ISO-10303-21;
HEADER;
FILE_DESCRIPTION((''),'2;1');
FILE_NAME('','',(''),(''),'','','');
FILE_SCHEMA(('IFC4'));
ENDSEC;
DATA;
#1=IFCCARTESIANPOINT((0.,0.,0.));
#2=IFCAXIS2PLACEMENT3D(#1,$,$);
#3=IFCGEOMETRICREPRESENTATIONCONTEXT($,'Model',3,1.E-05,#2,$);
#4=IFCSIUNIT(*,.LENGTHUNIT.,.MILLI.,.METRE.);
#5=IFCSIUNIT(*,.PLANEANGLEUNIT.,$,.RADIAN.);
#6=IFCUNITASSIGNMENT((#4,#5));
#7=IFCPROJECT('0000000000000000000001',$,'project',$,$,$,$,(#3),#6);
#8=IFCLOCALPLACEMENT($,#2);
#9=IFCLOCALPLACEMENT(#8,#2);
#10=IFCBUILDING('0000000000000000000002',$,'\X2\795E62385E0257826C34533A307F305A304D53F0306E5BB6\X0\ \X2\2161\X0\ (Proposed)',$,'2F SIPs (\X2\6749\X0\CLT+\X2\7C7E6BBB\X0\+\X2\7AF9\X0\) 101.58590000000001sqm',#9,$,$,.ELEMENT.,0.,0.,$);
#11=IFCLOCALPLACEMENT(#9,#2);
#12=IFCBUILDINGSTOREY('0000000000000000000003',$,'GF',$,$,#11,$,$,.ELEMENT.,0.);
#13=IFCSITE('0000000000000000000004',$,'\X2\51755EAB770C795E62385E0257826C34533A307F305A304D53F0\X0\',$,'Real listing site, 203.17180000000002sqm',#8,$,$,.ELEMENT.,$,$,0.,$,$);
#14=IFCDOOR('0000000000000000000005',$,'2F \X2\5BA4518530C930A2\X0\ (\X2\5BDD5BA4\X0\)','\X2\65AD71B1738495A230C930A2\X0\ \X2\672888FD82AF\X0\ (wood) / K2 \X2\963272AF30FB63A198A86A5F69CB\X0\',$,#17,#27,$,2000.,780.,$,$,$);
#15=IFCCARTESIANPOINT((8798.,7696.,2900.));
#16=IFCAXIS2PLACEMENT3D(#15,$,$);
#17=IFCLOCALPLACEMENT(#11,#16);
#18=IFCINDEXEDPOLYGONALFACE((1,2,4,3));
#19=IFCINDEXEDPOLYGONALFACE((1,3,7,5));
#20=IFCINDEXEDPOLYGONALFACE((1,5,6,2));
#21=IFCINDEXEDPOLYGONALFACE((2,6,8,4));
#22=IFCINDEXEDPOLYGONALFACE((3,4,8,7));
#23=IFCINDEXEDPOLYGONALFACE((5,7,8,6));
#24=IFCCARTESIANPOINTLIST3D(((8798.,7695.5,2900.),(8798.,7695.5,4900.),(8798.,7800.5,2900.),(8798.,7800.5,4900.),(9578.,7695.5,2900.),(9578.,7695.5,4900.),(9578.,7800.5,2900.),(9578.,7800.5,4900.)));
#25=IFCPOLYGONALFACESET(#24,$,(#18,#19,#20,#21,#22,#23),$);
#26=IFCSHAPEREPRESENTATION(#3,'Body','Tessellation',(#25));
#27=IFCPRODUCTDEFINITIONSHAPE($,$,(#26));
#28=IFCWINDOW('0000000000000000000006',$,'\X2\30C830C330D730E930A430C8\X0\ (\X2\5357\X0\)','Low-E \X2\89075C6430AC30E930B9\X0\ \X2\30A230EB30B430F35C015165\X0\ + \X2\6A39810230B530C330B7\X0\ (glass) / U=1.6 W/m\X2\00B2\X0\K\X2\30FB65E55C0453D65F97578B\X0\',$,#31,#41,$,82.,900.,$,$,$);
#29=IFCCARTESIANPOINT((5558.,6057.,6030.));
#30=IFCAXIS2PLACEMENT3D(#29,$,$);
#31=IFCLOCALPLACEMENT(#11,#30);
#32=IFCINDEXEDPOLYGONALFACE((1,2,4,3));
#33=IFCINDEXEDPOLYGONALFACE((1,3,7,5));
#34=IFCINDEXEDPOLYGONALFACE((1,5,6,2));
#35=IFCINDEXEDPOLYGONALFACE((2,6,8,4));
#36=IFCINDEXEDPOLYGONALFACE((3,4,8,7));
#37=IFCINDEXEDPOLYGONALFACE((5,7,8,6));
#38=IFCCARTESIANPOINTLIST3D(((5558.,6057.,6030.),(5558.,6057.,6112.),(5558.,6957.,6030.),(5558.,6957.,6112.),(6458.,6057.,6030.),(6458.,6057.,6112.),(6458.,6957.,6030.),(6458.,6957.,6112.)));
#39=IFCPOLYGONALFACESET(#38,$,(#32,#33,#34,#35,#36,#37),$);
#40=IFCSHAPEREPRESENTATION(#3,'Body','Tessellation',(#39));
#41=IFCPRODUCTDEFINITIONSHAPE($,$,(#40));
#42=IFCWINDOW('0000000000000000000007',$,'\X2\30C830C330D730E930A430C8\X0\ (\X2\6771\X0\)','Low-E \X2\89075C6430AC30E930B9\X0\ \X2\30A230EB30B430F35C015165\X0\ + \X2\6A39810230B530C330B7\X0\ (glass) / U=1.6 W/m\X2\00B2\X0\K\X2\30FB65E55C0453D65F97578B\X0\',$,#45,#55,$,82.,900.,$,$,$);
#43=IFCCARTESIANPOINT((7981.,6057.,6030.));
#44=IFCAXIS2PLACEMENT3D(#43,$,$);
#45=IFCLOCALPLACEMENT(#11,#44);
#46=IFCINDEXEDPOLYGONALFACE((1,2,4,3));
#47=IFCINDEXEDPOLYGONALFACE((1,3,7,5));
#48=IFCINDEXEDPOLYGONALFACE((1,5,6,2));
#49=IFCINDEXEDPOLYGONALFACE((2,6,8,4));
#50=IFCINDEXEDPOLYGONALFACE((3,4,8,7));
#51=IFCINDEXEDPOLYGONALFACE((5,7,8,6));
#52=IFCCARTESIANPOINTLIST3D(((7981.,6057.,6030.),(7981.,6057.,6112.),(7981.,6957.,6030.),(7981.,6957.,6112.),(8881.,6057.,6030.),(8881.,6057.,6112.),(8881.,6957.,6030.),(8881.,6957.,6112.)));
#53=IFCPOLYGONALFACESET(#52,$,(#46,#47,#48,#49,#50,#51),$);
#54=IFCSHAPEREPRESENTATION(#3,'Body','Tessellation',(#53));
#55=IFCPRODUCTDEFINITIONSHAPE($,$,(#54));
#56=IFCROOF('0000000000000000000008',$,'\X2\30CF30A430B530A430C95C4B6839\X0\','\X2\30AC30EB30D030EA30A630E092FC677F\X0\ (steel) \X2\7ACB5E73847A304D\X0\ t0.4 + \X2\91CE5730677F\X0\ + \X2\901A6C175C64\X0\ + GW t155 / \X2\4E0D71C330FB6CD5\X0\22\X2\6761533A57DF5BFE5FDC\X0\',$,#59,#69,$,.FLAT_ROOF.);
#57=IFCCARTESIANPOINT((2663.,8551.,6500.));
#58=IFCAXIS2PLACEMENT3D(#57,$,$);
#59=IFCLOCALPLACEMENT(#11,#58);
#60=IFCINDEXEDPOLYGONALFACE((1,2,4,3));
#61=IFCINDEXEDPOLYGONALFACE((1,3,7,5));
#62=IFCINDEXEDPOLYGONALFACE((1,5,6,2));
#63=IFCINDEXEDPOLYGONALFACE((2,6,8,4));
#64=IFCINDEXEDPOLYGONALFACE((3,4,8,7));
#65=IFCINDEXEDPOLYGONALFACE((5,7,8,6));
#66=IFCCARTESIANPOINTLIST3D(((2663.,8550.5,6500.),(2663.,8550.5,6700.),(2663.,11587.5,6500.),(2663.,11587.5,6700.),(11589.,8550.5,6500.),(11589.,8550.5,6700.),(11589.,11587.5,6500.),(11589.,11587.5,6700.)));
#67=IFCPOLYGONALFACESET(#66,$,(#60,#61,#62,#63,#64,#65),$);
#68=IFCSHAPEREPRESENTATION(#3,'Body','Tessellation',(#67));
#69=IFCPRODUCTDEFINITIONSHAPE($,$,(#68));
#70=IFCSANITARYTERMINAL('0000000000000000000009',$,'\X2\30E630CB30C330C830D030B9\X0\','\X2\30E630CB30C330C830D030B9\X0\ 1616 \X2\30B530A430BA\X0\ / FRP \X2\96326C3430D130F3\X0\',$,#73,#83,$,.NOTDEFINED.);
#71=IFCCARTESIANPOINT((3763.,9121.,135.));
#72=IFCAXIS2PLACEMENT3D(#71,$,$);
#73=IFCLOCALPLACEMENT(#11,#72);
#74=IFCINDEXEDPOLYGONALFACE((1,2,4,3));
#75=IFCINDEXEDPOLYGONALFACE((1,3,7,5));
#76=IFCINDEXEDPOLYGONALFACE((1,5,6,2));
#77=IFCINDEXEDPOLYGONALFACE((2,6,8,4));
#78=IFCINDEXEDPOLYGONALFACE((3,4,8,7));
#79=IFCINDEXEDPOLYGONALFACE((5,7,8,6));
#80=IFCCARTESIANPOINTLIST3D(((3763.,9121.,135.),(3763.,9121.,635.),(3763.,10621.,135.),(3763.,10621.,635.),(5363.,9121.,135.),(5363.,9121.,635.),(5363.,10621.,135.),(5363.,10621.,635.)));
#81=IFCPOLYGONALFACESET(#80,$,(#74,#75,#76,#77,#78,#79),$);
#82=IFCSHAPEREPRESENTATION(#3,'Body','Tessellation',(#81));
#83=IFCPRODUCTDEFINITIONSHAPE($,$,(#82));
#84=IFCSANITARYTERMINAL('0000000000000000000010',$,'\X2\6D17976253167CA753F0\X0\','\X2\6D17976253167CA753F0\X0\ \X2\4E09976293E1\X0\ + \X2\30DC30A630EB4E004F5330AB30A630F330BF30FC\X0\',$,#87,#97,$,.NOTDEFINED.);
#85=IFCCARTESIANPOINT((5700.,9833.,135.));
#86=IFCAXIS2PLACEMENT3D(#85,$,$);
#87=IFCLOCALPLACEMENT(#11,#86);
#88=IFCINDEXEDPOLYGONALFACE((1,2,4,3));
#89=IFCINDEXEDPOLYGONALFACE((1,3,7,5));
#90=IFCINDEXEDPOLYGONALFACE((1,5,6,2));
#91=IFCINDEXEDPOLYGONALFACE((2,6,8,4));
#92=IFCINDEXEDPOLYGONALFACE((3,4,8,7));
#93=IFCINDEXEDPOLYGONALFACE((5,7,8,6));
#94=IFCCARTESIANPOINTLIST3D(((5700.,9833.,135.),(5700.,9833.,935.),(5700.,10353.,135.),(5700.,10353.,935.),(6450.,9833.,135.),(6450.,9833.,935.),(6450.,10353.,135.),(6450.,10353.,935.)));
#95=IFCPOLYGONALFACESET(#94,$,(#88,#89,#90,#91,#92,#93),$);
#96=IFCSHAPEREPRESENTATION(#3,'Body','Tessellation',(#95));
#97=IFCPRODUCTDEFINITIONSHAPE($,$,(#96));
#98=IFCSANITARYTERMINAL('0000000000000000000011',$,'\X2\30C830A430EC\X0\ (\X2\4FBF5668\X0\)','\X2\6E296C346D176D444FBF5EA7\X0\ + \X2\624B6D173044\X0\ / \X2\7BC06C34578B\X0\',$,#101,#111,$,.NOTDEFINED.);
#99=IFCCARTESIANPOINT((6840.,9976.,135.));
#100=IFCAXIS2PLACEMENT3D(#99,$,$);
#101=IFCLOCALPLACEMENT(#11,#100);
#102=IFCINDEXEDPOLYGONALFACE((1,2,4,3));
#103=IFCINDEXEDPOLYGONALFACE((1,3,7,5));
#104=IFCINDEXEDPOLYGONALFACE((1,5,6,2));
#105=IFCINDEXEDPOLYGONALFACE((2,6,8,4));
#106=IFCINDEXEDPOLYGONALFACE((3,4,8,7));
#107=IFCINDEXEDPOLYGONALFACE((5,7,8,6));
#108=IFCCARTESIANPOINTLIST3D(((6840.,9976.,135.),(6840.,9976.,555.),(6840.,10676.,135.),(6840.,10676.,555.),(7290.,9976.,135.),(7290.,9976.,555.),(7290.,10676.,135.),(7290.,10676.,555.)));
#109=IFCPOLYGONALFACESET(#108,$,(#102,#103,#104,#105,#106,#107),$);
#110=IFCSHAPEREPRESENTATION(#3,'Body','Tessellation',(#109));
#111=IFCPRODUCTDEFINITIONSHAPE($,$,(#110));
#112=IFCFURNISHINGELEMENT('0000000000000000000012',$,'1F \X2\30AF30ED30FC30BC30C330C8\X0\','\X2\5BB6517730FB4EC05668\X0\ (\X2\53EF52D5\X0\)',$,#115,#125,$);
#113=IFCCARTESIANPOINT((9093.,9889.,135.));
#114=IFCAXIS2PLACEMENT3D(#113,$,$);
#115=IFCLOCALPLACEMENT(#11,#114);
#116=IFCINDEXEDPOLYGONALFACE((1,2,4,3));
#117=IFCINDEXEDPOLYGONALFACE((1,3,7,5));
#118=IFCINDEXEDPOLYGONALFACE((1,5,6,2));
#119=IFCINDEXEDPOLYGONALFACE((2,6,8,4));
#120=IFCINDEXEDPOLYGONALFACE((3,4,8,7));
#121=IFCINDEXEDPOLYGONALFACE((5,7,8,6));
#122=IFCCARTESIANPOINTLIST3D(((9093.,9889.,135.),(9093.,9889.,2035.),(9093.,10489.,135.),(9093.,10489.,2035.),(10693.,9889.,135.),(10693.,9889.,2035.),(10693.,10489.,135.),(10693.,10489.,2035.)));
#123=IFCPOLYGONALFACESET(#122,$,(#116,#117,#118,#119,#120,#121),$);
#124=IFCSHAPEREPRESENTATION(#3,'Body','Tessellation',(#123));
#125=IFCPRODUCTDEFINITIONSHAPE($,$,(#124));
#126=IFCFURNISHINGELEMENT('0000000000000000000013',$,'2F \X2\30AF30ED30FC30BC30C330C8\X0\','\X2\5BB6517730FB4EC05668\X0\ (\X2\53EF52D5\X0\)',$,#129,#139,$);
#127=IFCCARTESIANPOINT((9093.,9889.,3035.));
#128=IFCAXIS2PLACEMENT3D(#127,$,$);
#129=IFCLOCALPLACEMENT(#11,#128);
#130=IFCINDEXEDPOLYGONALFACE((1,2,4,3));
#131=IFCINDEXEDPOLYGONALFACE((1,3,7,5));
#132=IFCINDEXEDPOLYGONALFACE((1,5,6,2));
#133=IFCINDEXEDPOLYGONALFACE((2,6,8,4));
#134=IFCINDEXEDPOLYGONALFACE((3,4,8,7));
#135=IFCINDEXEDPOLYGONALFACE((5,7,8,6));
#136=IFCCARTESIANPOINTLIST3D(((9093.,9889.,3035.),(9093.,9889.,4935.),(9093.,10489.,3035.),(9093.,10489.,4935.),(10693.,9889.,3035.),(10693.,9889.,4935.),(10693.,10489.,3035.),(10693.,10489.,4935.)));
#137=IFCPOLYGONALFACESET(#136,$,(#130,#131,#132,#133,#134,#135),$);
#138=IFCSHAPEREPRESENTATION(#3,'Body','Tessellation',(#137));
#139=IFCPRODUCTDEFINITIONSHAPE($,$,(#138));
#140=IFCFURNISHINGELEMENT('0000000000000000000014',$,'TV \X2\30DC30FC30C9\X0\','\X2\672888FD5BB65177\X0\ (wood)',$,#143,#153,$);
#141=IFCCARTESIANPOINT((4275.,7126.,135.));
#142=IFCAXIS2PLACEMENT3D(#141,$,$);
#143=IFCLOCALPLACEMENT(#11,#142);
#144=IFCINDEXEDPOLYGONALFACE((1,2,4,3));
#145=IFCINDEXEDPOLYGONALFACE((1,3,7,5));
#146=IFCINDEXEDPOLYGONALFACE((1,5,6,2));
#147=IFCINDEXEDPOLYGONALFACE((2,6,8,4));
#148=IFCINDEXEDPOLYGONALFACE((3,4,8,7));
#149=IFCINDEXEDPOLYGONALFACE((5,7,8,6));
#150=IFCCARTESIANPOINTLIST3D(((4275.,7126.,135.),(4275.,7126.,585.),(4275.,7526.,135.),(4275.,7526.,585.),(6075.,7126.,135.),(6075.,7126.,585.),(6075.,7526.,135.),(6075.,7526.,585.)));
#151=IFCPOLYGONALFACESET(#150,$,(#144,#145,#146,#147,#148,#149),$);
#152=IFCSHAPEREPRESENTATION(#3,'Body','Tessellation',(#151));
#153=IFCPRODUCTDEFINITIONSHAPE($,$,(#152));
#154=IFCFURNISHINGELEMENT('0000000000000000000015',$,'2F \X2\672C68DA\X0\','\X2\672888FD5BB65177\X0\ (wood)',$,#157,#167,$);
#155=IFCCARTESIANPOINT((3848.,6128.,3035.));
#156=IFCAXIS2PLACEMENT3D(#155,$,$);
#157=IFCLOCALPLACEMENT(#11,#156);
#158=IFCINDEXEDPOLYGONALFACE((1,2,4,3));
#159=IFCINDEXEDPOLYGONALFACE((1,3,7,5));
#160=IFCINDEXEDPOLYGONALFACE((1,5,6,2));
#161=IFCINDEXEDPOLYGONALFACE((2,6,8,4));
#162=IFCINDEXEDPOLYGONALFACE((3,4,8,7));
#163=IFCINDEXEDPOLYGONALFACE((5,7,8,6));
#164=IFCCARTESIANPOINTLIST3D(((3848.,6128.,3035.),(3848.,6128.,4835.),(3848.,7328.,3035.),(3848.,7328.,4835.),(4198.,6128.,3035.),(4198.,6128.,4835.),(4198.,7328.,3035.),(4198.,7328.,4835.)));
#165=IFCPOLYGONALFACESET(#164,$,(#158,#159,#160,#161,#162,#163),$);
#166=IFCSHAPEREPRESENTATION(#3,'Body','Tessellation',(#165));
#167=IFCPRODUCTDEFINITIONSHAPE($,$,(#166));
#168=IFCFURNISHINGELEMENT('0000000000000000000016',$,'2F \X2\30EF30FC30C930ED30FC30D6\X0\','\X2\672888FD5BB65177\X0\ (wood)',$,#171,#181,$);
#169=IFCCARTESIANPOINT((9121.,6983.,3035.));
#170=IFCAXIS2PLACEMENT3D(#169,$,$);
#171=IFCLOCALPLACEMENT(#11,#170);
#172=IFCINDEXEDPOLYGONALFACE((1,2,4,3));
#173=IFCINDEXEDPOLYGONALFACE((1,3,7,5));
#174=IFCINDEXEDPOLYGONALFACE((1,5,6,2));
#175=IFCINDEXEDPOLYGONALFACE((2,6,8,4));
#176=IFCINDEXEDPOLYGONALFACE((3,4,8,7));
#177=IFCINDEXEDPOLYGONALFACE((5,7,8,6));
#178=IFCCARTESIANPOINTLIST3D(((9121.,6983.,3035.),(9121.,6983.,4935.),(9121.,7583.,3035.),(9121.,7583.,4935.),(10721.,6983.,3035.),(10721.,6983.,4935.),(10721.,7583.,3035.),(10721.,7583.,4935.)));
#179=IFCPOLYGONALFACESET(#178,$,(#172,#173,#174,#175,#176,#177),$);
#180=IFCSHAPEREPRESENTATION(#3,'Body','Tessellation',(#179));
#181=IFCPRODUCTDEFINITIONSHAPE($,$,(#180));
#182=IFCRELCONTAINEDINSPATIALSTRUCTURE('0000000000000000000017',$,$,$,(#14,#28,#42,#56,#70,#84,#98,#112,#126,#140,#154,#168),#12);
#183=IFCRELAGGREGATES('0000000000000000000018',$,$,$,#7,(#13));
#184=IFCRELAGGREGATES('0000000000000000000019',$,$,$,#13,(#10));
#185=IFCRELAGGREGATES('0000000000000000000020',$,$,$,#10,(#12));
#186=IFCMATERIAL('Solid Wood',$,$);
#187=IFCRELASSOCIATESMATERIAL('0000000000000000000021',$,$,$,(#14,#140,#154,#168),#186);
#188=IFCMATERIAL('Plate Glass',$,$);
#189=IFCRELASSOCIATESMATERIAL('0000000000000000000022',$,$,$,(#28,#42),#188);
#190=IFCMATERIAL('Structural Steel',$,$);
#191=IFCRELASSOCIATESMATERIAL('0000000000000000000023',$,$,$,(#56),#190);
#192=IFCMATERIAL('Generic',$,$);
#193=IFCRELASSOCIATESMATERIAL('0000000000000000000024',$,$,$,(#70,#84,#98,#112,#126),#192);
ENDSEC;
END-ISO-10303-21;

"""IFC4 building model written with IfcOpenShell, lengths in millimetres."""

from ifc_helpers import new_model, si_unit, frame, frame_2d, origin, place, context, project, spatial, rectangle, extrude, material, element, save


model = new_model("IFC4")

# Units and contexts
model_context = context("Model", 3, precision=1e-05, world=origin())
ifc_project = project(units=[si_unit("LENGTHUNIT", "METRE", prefix="MILLI"), si_unit("PLANEANGLEUNIT", "RADIAN")], contexts=[model_context])

# Site, building, storey
site_placement = place(None, origin())
site = spatial("IfcSite", under=ifc_project, at=site_placement, Name="兵庫県神戸市垂水区みずき台", ObjectType="Real listing site, 203.17180000000002sqm", CompositionType="ELEMENT", RefElevation=0.0)
building_placement = place(site_placement, origin())
building = spatial("IfcBuilding", under=site, at=building_placement, Name="神戸市垂水区みずき台の家 Ⅱ (Proposed)", ObjectType="2F SIPs (杉CLT+籾殻+竹) 101.58590000000001sqm", CompositionType="ELEMENT", ElevationOfRefHeight=0.0, ElevationOfTerrain=0.0)
storey_placement = place(building_placement, origin())
storey = spatial("IfcBuildingStorey", under=building, at=storey_placement, Name="GF", CompositionType="ELEMENT", Elevation=0.0)

# Shared definitions
ifc_material_1 = material(Name="Solid Wood")
ifc_material_2 = material(Name="Plate Glass")

# Door
door_1_placement = place(storey_placement, frame((8798.0, 7696.0, 2900.0)))
element("IfcDoor", 1, at=door_1_placement, inside=storey, material=ifc_material_1, Name="2F 室内ドア (寝室)", Description="断熱玄関ドア 木製芯 (wood) / K2 防犯・採風機構", OverallHeight=2000.0, OverallWidth=780.0, context=model_context, shape_type="SweptSolid", body=[
    extrude(rectangle(XDim=780.0, YDim=105.0, at=frame_2d((390.0, 52.0))), frame((8798.0, 7696.0, 2900.0)), (0.0, 0.0, 1.0), 2000.0),
])

# Windows
window_1_placement = place(storey_placement, frame((5558.0, 6057.0, 6030.0)))
element("IfcWindow", 2, at=window_1_placement, inside=storey, material=ifc_material_2, Name="トップライト (南)", Description="Low-E 複層ガラス アルゴン封入 + 樹脂サッシ (glass) / U=1.6 W/m²K・日射取得型", OverallHeight=82.0, OverallWidth=900.0, context=model_context, shape_type="SweptSolid", body=[
    extrude(rectangle(XDim=900.0, YDim=900.0, at=frame_2d((450.0, 450.0))), frame((5558.0, 6057.0, 6030.0)), (0.0, 0.0, 1.0), 82.0),
])
window_2_placement = place(storey_placement, frame((7981.0, 6057.0, 6030.0)))
element("IfcWindow", 3, at=window_2_placement, inside=storey, material=ifc_material_2, Name="トップライト (東)", Description="Low-E 複層ガラス アルゴン封入 + 樹脂サッシ (glass) / U=1.6 W/m²K・日射取得型", OverallHeight=82.0, OverallWidth=900.0, context=model_context, shape_type="SweptSolid", body=[
    extrude(rectangle(XDim=900.0, YDim=900.0, at=frame_2d((450.0, 450.0))), frame((7981.0, 6057.0, 6030.0)), (0.0, 0.0, 1.0), 82.0),
])

# Roof
ifc_material_3 = material(Name="Structural Steel")
roof_placement = place(storey_placement, frame((2663.0, 8551.0, 6500.0)))
element("IfcRoof", 4, at=roof_placement, inside=storey, material=ifc_material_3, Name="ハイサイド屋根", Description="ガルバリウム鋼板 (steel) 立平葺き t0.4 + 野地板 + 通気層 + GW t155 / 不燃・法22条区域対応", PredefinedType="FLAT_ROOF", context=model_context, shape_type="SweptSolid", body=[
    extrude(rectangle(XDim=8926.0, YDim=3037.0, at=frame_2d((4463.0, 1518.0))), frame((2663.0, 8551.0, 6500.0)), (0.0, 0.0, 1.0), 200.0),
])

# Sanitary terminals
ifc_material_4 = material(Name="Generic")
sanitary_terminal_1_placement = place(storey_placement, frame((3763.0, 9121.0, 135.0)))
element("IfcSanitaryTerminal", 5, at=sanitary_terminal_1_placement, inside=storey, material=ifc_material_4, Name="ユニットバス", Description="ユニットバス 1616 サイズ / FRP 防水パン", PredefinedType="NOTDEFINED", context=model_context, shape_type="SweptSolid", body=[
    extrude(rectangle(XDim=1600.0, YDim=1500.0, at=frame_2d((800.0, 750.0))), frame((3763.0, 9121.0, 135.0)), (0.0, 0.0, 1.0), 500.0),
])
sanitary_terminal_2_placement = place(storey_placement, frame((5700.0, 9833.0, 135.0)))
element("IfcSanitaryTerminal", 6, at=sanitary_terminal_2_placement, inside=storey, material=ifc_material_4, Name="洗面化粧台", Description="洗面化粧台 三面鏡 + ボウル一体カウンター", PredefinedType="NOTDEFINED", context=model_context, shape_type="SweptSolid", body=[
    extrude(rectangle(XDim=750.0, YDim=520.0, at=frame_2d((375.0, 260.0))), frame((5700.0, 9833.0, 135.0)), (0.0, 0.0, 1.0), 800.0),
])
sanitary_terminal_3_placement = place(storey_placement, frame((6840.0, 9976.0, 135.0)))
element("IfcSanitaryTerminal", 7, at=sanitary_terminal_3_placement, inside=storey, material=ifc_material_4, Name="トイレ (便器)", Description="温水洗浄便座 + 手洗い / 節水型", PredefinedType="NOTDEFINED", context=model_context, shape_type="SweptSolid", body=[
    extrude(rectangle(XDim=450.0, YDim=700.0, at=frame_2d((225.0, 350.0))), frame((6840.0, 9976.0, 135.0)), (0.0, 0.0, 1.0), 420.0),
])

# Furnishing elements
furnishing_1_placement = place(storey_placement, frame((9093.0, 9889.0, 135.0)))
element("IfcFurnishingElement", 8, at=furnishing_1_placement, inside=storey, material=ifc_material_4, Name="1F クローゼット", Description="家具・什器 (可動)", context=model_context, shape_type="SweptSolid", body=[
    extrude(rectangle(XDim=1600.0, YDim=600.0, at=frame_2d((800.0, 300.0))), frame((9093.0, 9889.0, 135.0)), (0.0, 0.0, 1.0), 1900.0),
])
furnishing_2_placement = place(storey_placement, frame((9093.0, 9889.0, 3035.0)))
element("IfcFurnishingElement", 9, at=furnishing_2_placement, inside=storey, material=ifc_material_4, Name="2F クローゼット", Description="家具・什器 (可動)", context=model_context, shape_type="SweptSolid", body=[
    extrude(rectangle(XDim=1600.0, YDim=600.0, at=frame_2d((800.0, 300.0))), frame((9093.0, 9889.0, 3035.0)), (0.0, 0.0, 1.0), 1900.0),
])
furnishing_3_placement = place(storey_placement, frame((4275.0, 7126.0, 135.0)))
element("IfcFurnishingElement", 10, at=furnishing_3_placement, inside=storey, material=ifc_material_1, Name="TV ボード", Description="木製家具 (wood)", context=model_context, shape_type="SweptSolid", body=[
    extrude(rectangle(XDim=1800.0, YDim=400.0, at=frame_2d((900.0, 200.0))), frame((4275.0, 7126.0, 135.0)), (0.0, 0.0, 1.0), 450.0),
])
furnishing_4_placement = place(storey_placement, frame((3848.0, 6128.0, 3035.0)))
element("IfcFurnishingElement", 11, at=furnishing_4_placement, inside=storey, material=ifc_material_1, Name="2F 本棚", Description="木製家具 (wood)", context=model_context, shape_type="SweptSolid", body=[
    extrude(rectangle(XDim=350.0, YDim=1200.0, at=frame_2d((175.0, 600.0))), frame((3848.0, 6128.0, 3035.0)), (0.0, 0.0, 1.0), 1800.0),
])
furnishing_5_placement = place(storey_placement, frame((9121.0, 6983.0, 3035.0)))
element("IfcFurnishingElement", 12, at=furnishing_5_placement, inside=storey, material=ifc_material_1, Name="2F ワードローブ", Description="木製家具 (wood)", context=model_context, shape_type="SweptSolid", body=[
    extrude(rectangle(XDim=1600.0, YDim=600.0, at=frame_2d((800.0, 300.0))), frame((9121.0, 6983.0, 3035.0)), (0.0, 0.0, 1.0), 1900.0),
])

save(model, "model.ifc")
